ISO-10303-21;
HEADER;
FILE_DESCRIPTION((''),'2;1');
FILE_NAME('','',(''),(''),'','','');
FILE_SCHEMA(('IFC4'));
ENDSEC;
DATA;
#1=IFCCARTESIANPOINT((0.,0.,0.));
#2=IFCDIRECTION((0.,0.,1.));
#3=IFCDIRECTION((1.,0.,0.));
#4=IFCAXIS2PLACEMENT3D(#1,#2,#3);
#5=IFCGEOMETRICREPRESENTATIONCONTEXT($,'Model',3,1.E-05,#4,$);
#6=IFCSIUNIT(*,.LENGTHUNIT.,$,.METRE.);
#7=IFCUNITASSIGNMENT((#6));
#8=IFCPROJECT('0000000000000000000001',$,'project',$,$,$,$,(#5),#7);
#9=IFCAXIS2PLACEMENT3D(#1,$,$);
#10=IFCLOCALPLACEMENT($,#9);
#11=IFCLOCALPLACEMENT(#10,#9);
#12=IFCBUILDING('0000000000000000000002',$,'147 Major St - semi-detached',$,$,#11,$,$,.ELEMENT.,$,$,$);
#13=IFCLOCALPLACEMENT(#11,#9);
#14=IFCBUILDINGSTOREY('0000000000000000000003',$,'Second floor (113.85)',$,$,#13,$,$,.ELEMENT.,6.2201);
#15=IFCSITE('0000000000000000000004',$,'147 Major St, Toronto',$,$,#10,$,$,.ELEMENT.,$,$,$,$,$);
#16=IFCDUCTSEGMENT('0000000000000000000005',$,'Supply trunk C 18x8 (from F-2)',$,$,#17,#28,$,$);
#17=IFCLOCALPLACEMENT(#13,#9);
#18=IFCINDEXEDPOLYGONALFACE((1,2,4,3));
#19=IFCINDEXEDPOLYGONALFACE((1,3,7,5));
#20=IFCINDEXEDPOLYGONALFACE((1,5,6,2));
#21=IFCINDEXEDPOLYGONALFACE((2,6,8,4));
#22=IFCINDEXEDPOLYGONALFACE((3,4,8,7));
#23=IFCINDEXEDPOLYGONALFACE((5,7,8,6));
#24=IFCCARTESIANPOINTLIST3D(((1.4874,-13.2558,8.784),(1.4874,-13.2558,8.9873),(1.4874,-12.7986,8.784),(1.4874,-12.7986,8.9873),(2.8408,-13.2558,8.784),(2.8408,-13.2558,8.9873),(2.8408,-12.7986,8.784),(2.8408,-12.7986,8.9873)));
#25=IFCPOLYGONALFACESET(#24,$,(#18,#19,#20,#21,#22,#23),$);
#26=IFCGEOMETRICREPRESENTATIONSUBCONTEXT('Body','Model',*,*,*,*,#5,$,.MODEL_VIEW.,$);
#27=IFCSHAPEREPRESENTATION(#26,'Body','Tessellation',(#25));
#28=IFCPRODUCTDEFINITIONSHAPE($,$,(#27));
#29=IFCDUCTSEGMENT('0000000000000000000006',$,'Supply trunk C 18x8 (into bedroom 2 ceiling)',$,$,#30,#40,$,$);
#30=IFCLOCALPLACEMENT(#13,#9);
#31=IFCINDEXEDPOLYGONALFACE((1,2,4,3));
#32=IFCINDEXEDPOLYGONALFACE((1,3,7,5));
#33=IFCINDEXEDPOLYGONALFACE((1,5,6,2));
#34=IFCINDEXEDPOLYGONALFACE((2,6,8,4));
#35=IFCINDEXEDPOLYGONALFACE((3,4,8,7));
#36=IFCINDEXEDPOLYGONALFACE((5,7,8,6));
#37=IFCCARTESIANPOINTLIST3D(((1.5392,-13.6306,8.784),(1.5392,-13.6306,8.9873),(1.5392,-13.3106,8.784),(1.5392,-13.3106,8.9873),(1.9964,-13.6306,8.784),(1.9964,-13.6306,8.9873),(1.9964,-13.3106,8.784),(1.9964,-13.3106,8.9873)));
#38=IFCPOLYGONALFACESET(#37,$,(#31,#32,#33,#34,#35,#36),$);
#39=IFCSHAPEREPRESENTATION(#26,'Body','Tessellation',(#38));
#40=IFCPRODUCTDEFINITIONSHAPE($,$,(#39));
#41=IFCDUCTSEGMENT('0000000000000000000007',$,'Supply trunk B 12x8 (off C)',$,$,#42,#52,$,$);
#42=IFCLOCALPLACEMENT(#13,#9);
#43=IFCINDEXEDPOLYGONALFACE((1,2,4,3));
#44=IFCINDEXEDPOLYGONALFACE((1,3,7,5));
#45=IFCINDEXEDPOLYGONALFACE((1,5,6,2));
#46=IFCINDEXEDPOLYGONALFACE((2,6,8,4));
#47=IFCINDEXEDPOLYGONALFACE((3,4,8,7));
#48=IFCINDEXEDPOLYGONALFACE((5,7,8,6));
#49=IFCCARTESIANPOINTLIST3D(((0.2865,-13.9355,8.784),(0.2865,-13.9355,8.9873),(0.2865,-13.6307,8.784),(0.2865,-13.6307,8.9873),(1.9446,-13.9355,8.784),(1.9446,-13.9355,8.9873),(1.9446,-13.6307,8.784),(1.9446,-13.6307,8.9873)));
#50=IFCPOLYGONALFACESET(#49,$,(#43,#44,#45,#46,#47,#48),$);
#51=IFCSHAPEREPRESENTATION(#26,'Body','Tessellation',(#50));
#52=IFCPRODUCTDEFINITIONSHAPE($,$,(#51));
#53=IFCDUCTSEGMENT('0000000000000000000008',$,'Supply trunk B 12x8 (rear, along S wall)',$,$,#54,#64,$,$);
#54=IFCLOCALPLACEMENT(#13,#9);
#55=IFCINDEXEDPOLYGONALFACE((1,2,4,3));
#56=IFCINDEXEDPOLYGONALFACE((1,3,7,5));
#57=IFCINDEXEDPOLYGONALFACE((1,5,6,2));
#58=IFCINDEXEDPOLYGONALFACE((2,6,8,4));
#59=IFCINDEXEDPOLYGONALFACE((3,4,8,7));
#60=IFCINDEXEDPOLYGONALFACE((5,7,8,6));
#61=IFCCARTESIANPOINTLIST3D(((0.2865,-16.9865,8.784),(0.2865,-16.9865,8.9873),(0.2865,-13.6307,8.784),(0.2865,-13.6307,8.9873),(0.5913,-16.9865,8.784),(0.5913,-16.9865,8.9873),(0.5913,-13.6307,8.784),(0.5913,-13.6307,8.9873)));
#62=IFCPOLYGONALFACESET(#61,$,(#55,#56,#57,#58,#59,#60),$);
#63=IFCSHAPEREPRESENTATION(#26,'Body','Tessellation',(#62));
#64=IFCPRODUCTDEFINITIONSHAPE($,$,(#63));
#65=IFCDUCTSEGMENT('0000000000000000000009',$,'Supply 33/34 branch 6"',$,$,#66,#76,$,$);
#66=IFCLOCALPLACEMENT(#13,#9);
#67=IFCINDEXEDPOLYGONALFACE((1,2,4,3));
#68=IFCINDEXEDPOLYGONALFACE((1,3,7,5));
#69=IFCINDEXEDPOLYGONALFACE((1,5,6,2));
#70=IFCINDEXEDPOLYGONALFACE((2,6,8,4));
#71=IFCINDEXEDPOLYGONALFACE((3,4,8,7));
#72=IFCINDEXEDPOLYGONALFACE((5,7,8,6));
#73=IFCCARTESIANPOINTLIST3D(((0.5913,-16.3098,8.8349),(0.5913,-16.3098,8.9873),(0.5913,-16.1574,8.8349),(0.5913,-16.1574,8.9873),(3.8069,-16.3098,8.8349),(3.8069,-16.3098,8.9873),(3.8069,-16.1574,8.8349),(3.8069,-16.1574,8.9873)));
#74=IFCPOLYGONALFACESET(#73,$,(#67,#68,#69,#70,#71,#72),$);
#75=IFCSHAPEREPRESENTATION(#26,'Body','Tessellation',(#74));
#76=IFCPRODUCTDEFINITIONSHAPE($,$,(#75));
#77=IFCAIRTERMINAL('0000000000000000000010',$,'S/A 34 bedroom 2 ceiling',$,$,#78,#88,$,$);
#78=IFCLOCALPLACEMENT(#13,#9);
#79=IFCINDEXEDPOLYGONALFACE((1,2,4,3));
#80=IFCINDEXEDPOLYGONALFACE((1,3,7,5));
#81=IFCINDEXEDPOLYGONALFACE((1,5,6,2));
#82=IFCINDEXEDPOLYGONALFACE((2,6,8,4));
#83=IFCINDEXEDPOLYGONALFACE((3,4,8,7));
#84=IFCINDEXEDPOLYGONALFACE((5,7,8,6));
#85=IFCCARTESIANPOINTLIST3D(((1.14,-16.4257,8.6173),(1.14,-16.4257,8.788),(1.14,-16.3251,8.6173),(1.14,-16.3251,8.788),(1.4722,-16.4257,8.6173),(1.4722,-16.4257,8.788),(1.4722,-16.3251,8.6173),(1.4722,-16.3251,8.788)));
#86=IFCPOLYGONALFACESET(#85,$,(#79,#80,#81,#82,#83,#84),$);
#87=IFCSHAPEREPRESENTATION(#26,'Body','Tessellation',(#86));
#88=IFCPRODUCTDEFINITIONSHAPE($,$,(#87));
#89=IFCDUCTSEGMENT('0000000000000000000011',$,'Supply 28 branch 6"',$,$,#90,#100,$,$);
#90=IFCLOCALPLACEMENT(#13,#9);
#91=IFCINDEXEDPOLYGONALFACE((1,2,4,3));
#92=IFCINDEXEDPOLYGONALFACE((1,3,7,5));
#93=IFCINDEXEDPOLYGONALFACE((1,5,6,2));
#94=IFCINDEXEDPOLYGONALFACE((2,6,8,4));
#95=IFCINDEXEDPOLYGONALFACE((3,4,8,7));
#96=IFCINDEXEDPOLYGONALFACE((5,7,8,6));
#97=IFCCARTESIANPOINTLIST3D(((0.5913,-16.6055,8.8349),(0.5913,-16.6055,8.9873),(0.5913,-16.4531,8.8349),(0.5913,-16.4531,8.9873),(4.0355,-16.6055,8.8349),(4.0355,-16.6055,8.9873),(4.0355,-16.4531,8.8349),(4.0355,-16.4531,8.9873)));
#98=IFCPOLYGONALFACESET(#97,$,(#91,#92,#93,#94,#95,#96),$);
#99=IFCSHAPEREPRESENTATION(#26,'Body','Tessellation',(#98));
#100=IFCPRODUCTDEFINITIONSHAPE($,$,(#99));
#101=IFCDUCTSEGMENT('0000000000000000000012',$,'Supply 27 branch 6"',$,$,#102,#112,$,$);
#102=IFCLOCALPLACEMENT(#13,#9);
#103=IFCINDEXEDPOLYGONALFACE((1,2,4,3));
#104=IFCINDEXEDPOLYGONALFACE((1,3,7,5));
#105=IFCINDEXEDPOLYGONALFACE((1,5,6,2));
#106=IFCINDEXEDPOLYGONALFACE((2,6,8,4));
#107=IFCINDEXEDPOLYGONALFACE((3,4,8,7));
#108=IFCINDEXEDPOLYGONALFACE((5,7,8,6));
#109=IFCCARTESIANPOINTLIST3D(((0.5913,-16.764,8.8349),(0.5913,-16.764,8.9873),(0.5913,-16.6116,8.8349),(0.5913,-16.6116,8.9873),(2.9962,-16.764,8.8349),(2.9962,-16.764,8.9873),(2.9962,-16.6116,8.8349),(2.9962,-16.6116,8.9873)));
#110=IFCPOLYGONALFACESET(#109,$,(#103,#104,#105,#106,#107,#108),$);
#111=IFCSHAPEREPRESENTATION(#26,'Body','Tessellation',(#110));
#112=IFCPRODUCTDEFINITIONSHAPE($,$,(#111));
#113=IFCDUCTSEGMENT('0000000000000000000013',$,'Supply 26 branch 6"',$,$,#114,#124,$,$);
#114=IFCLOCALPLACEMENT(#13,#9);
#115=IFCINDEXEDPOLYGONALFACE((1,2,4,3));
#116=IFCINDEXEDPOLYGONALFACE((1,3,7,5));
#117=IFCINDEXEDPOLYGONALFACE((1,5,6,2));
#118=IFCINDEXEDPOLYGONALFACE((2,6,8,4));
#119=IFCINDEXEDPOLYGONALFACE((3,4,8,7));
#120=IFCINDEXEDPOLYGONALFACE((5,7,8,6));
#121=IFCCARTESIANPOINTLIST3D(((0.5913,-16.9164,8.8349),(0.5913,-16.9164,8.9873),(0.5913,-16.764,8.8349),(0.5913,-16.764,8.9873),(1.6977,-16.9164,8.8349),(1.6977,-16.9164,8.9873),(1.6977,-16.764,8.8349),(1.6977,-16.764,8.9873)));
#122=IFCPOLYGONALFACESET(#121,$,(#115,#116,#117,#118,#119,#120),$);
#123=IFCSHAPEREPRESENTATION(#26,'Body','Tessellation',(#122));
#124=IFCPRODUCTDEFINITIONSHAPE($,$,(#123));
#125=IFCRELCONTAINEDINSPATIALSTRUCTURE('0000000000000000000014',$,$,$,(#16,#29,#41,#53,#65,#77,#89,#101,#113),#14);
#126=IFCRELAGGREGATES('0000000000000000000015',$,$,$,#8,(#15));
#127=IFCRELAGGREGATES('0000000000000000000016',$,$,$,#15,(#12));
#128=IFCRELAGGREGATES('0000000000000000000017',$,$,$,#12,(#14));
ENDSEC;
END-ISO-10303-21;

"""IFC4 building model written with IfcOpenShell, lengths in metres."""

from ifc_helpers import new_model, si_unit, frame, origin, origin_with_axes, place, context, subcontext, project, spatial, rectangle, extrude, element, save


model = new_model("IFC4")

# Units and contexts
model_context = context("Model", 3, precision=1e-05, world=origin_with_axes())
body_context = subcontext(model_context, "Body", "Model", "MODEL_VIEW")
ifc_project = project(units=[si_unit("LENGTHUNIT", "METRE")], contexts=[model_context])

# Site, building, storey
site_placement = place(None, origin())
site = spatial("IfcSite", under=ifc_project, at=site_placement, Name="147 Major St, Toronto", CompositionType="ELEMENT")
building_placement = place(site_placement, origin())
building = spatial("IfcBuilding", under=site, at=building_placement, Name="147 Major St - semi-detached", CompositionType="ELEMENT")
storey_placement = place(building_placement, origin())
storey = spatial("IfcBuildingStorey", under=building, at=storey_placement, Name="Second floor (113.85)", CompositionType="ELEMENT", Elevation=6.2201)

# Duct segments
duct_segment_1_placement = place(storey_placement, frame((2.1641, -13.0272, 8.784)))
element("IfcDuctSegment", 1, at=duct_segment_1_placement, inside=storey, Name="Supply trunk C 18x8 (from F-2)", context=body_context, shape_type="SweptSolid", body=[
    extrude(rectangle(XDim=1.3533, YDim=0.4572), origin_with_axes(), (0.0, 0.0, 1.0), 0.2033),
])
duct_segment_2_placement = place(storey_placement, frame((1.7678, -13.4706, 8.784)))
element("IfcDuctSegment", 2, at=duct_segment_2_placement, inside=storey, Name="Supply trunk C 18x8 (into bedroom 2 ceiling)", context=body_context, shape_type="SweptSolid", body=[
    extrude(rectangle(XDim=0.4572, YDim=0.32), origin_with_axes(), (0.0, 0.0, 1.0), 0.2033),
])
duct_segment_3_placement = place(storey_placement, frame((1.1156, -13.7831, 8.784)))
element("IfcDuctSegment", 3, at=duct_segment_3_placement, inside=storey, Name="Supply trunk B 12x8 (off C)", context=body_context, shape_type="SweptSolid", body=[
    extrude(rectangle(XDim=1.6581, YDim=0.3048), origin_with_axes(), (0.0, 0.0, 1.0), 0.2033),
])
duct_segment_4_placement = place(storey_placement, frame((0.4389, -15.3086, 8.784)))
element("IfcDuctSegment", 4, at=duct_segment_4_placement, inside=storey, Name="Supply trunk B 12x8 (rear, along S wall)", context=body_context, shape_type="SweptSolid", body=[
    extrude(rectangle(XDim=0.3048, YDim=3.3558), origin_with_axes(), (0.0, 0.0, 1.0), 0.2033),
])
duct_segment_5_placement = place(storey_placement, frame((2.1991, -16.2336, 8.8349)))
element("IfcDuctSegment", 5, at=duct_segment_5_placement, inside=storey, Name="Supply 33/34 branch 6\"", context=body_context, shape_type="SweptSolid", body=[
    extrude(rectangle(XDim=3.2156, YDim=0.1524), origin_with_axes(), (0.0, 0.0, 1.0), 0.1524),
])

# Air terminal
air_terminal_placement = place(storey_placement, frame((1.3061, -16.3754, 8.6173)))
element("IfcAirTerminal", 6, at=air_terminal_placement, inside=storey, Name="S/A 34 bedroom 2 ceiling", context=body_context, shape_type="SweptSolid", body=[
    extrude(rectangle(XDim=0.3322, YDim=0.1006), origin_with_axes(), (0.0, 0.0, 1.0), 0.1707),
])

# Duct segments
duct_segment_6_placement = place(storey_placement, frame((2.3134, -16.5293, 8.8349)))
element("IfcDuctSegment", 7, at=duct_segment_6_placement, inside=storey, Name="Supply 28 branch 6\"", context=body_context, shape_type="SweptSolid", body=[
    extrude(rectangle(XDim=3.4442, YDim=0.1524), origin_with_axes(), (0.0, 0.0, 1.0), 0.1524),
])
duct_segment_7_placement = place(storey_placement, frame((1.7937, -16.6878, 8.8349)))
element("IfcDuctSegment", 8, at=duct_segment_7_placement, inside=storey, Name="Supply 27 branch 6\"", context=body_context, shape_type="SweptSolid", body=[
    extrude(rectangle(XDim=2.4049, YDim=0.1524), origin_with_axes(), (0.0, 0.0, 1.0), 0.1524),
])
duct_segment_8_placement = place(storey_placement, frame((1.1445, -16.8402, 8.8349)))
element("IfcDuctSegment", 9, at=duct_segment_8_placement, inside=storey, Name="Supply 26 branch 6\"", context=body_context, shape_type="SweptSolid", body=[
    extrude(rectangle(XDim=1.1064, YDim=0.1524), origin_with_axes(), (0.0, 0.0, 1.0), 0.1524),
])

save(model, "model.ifc")
